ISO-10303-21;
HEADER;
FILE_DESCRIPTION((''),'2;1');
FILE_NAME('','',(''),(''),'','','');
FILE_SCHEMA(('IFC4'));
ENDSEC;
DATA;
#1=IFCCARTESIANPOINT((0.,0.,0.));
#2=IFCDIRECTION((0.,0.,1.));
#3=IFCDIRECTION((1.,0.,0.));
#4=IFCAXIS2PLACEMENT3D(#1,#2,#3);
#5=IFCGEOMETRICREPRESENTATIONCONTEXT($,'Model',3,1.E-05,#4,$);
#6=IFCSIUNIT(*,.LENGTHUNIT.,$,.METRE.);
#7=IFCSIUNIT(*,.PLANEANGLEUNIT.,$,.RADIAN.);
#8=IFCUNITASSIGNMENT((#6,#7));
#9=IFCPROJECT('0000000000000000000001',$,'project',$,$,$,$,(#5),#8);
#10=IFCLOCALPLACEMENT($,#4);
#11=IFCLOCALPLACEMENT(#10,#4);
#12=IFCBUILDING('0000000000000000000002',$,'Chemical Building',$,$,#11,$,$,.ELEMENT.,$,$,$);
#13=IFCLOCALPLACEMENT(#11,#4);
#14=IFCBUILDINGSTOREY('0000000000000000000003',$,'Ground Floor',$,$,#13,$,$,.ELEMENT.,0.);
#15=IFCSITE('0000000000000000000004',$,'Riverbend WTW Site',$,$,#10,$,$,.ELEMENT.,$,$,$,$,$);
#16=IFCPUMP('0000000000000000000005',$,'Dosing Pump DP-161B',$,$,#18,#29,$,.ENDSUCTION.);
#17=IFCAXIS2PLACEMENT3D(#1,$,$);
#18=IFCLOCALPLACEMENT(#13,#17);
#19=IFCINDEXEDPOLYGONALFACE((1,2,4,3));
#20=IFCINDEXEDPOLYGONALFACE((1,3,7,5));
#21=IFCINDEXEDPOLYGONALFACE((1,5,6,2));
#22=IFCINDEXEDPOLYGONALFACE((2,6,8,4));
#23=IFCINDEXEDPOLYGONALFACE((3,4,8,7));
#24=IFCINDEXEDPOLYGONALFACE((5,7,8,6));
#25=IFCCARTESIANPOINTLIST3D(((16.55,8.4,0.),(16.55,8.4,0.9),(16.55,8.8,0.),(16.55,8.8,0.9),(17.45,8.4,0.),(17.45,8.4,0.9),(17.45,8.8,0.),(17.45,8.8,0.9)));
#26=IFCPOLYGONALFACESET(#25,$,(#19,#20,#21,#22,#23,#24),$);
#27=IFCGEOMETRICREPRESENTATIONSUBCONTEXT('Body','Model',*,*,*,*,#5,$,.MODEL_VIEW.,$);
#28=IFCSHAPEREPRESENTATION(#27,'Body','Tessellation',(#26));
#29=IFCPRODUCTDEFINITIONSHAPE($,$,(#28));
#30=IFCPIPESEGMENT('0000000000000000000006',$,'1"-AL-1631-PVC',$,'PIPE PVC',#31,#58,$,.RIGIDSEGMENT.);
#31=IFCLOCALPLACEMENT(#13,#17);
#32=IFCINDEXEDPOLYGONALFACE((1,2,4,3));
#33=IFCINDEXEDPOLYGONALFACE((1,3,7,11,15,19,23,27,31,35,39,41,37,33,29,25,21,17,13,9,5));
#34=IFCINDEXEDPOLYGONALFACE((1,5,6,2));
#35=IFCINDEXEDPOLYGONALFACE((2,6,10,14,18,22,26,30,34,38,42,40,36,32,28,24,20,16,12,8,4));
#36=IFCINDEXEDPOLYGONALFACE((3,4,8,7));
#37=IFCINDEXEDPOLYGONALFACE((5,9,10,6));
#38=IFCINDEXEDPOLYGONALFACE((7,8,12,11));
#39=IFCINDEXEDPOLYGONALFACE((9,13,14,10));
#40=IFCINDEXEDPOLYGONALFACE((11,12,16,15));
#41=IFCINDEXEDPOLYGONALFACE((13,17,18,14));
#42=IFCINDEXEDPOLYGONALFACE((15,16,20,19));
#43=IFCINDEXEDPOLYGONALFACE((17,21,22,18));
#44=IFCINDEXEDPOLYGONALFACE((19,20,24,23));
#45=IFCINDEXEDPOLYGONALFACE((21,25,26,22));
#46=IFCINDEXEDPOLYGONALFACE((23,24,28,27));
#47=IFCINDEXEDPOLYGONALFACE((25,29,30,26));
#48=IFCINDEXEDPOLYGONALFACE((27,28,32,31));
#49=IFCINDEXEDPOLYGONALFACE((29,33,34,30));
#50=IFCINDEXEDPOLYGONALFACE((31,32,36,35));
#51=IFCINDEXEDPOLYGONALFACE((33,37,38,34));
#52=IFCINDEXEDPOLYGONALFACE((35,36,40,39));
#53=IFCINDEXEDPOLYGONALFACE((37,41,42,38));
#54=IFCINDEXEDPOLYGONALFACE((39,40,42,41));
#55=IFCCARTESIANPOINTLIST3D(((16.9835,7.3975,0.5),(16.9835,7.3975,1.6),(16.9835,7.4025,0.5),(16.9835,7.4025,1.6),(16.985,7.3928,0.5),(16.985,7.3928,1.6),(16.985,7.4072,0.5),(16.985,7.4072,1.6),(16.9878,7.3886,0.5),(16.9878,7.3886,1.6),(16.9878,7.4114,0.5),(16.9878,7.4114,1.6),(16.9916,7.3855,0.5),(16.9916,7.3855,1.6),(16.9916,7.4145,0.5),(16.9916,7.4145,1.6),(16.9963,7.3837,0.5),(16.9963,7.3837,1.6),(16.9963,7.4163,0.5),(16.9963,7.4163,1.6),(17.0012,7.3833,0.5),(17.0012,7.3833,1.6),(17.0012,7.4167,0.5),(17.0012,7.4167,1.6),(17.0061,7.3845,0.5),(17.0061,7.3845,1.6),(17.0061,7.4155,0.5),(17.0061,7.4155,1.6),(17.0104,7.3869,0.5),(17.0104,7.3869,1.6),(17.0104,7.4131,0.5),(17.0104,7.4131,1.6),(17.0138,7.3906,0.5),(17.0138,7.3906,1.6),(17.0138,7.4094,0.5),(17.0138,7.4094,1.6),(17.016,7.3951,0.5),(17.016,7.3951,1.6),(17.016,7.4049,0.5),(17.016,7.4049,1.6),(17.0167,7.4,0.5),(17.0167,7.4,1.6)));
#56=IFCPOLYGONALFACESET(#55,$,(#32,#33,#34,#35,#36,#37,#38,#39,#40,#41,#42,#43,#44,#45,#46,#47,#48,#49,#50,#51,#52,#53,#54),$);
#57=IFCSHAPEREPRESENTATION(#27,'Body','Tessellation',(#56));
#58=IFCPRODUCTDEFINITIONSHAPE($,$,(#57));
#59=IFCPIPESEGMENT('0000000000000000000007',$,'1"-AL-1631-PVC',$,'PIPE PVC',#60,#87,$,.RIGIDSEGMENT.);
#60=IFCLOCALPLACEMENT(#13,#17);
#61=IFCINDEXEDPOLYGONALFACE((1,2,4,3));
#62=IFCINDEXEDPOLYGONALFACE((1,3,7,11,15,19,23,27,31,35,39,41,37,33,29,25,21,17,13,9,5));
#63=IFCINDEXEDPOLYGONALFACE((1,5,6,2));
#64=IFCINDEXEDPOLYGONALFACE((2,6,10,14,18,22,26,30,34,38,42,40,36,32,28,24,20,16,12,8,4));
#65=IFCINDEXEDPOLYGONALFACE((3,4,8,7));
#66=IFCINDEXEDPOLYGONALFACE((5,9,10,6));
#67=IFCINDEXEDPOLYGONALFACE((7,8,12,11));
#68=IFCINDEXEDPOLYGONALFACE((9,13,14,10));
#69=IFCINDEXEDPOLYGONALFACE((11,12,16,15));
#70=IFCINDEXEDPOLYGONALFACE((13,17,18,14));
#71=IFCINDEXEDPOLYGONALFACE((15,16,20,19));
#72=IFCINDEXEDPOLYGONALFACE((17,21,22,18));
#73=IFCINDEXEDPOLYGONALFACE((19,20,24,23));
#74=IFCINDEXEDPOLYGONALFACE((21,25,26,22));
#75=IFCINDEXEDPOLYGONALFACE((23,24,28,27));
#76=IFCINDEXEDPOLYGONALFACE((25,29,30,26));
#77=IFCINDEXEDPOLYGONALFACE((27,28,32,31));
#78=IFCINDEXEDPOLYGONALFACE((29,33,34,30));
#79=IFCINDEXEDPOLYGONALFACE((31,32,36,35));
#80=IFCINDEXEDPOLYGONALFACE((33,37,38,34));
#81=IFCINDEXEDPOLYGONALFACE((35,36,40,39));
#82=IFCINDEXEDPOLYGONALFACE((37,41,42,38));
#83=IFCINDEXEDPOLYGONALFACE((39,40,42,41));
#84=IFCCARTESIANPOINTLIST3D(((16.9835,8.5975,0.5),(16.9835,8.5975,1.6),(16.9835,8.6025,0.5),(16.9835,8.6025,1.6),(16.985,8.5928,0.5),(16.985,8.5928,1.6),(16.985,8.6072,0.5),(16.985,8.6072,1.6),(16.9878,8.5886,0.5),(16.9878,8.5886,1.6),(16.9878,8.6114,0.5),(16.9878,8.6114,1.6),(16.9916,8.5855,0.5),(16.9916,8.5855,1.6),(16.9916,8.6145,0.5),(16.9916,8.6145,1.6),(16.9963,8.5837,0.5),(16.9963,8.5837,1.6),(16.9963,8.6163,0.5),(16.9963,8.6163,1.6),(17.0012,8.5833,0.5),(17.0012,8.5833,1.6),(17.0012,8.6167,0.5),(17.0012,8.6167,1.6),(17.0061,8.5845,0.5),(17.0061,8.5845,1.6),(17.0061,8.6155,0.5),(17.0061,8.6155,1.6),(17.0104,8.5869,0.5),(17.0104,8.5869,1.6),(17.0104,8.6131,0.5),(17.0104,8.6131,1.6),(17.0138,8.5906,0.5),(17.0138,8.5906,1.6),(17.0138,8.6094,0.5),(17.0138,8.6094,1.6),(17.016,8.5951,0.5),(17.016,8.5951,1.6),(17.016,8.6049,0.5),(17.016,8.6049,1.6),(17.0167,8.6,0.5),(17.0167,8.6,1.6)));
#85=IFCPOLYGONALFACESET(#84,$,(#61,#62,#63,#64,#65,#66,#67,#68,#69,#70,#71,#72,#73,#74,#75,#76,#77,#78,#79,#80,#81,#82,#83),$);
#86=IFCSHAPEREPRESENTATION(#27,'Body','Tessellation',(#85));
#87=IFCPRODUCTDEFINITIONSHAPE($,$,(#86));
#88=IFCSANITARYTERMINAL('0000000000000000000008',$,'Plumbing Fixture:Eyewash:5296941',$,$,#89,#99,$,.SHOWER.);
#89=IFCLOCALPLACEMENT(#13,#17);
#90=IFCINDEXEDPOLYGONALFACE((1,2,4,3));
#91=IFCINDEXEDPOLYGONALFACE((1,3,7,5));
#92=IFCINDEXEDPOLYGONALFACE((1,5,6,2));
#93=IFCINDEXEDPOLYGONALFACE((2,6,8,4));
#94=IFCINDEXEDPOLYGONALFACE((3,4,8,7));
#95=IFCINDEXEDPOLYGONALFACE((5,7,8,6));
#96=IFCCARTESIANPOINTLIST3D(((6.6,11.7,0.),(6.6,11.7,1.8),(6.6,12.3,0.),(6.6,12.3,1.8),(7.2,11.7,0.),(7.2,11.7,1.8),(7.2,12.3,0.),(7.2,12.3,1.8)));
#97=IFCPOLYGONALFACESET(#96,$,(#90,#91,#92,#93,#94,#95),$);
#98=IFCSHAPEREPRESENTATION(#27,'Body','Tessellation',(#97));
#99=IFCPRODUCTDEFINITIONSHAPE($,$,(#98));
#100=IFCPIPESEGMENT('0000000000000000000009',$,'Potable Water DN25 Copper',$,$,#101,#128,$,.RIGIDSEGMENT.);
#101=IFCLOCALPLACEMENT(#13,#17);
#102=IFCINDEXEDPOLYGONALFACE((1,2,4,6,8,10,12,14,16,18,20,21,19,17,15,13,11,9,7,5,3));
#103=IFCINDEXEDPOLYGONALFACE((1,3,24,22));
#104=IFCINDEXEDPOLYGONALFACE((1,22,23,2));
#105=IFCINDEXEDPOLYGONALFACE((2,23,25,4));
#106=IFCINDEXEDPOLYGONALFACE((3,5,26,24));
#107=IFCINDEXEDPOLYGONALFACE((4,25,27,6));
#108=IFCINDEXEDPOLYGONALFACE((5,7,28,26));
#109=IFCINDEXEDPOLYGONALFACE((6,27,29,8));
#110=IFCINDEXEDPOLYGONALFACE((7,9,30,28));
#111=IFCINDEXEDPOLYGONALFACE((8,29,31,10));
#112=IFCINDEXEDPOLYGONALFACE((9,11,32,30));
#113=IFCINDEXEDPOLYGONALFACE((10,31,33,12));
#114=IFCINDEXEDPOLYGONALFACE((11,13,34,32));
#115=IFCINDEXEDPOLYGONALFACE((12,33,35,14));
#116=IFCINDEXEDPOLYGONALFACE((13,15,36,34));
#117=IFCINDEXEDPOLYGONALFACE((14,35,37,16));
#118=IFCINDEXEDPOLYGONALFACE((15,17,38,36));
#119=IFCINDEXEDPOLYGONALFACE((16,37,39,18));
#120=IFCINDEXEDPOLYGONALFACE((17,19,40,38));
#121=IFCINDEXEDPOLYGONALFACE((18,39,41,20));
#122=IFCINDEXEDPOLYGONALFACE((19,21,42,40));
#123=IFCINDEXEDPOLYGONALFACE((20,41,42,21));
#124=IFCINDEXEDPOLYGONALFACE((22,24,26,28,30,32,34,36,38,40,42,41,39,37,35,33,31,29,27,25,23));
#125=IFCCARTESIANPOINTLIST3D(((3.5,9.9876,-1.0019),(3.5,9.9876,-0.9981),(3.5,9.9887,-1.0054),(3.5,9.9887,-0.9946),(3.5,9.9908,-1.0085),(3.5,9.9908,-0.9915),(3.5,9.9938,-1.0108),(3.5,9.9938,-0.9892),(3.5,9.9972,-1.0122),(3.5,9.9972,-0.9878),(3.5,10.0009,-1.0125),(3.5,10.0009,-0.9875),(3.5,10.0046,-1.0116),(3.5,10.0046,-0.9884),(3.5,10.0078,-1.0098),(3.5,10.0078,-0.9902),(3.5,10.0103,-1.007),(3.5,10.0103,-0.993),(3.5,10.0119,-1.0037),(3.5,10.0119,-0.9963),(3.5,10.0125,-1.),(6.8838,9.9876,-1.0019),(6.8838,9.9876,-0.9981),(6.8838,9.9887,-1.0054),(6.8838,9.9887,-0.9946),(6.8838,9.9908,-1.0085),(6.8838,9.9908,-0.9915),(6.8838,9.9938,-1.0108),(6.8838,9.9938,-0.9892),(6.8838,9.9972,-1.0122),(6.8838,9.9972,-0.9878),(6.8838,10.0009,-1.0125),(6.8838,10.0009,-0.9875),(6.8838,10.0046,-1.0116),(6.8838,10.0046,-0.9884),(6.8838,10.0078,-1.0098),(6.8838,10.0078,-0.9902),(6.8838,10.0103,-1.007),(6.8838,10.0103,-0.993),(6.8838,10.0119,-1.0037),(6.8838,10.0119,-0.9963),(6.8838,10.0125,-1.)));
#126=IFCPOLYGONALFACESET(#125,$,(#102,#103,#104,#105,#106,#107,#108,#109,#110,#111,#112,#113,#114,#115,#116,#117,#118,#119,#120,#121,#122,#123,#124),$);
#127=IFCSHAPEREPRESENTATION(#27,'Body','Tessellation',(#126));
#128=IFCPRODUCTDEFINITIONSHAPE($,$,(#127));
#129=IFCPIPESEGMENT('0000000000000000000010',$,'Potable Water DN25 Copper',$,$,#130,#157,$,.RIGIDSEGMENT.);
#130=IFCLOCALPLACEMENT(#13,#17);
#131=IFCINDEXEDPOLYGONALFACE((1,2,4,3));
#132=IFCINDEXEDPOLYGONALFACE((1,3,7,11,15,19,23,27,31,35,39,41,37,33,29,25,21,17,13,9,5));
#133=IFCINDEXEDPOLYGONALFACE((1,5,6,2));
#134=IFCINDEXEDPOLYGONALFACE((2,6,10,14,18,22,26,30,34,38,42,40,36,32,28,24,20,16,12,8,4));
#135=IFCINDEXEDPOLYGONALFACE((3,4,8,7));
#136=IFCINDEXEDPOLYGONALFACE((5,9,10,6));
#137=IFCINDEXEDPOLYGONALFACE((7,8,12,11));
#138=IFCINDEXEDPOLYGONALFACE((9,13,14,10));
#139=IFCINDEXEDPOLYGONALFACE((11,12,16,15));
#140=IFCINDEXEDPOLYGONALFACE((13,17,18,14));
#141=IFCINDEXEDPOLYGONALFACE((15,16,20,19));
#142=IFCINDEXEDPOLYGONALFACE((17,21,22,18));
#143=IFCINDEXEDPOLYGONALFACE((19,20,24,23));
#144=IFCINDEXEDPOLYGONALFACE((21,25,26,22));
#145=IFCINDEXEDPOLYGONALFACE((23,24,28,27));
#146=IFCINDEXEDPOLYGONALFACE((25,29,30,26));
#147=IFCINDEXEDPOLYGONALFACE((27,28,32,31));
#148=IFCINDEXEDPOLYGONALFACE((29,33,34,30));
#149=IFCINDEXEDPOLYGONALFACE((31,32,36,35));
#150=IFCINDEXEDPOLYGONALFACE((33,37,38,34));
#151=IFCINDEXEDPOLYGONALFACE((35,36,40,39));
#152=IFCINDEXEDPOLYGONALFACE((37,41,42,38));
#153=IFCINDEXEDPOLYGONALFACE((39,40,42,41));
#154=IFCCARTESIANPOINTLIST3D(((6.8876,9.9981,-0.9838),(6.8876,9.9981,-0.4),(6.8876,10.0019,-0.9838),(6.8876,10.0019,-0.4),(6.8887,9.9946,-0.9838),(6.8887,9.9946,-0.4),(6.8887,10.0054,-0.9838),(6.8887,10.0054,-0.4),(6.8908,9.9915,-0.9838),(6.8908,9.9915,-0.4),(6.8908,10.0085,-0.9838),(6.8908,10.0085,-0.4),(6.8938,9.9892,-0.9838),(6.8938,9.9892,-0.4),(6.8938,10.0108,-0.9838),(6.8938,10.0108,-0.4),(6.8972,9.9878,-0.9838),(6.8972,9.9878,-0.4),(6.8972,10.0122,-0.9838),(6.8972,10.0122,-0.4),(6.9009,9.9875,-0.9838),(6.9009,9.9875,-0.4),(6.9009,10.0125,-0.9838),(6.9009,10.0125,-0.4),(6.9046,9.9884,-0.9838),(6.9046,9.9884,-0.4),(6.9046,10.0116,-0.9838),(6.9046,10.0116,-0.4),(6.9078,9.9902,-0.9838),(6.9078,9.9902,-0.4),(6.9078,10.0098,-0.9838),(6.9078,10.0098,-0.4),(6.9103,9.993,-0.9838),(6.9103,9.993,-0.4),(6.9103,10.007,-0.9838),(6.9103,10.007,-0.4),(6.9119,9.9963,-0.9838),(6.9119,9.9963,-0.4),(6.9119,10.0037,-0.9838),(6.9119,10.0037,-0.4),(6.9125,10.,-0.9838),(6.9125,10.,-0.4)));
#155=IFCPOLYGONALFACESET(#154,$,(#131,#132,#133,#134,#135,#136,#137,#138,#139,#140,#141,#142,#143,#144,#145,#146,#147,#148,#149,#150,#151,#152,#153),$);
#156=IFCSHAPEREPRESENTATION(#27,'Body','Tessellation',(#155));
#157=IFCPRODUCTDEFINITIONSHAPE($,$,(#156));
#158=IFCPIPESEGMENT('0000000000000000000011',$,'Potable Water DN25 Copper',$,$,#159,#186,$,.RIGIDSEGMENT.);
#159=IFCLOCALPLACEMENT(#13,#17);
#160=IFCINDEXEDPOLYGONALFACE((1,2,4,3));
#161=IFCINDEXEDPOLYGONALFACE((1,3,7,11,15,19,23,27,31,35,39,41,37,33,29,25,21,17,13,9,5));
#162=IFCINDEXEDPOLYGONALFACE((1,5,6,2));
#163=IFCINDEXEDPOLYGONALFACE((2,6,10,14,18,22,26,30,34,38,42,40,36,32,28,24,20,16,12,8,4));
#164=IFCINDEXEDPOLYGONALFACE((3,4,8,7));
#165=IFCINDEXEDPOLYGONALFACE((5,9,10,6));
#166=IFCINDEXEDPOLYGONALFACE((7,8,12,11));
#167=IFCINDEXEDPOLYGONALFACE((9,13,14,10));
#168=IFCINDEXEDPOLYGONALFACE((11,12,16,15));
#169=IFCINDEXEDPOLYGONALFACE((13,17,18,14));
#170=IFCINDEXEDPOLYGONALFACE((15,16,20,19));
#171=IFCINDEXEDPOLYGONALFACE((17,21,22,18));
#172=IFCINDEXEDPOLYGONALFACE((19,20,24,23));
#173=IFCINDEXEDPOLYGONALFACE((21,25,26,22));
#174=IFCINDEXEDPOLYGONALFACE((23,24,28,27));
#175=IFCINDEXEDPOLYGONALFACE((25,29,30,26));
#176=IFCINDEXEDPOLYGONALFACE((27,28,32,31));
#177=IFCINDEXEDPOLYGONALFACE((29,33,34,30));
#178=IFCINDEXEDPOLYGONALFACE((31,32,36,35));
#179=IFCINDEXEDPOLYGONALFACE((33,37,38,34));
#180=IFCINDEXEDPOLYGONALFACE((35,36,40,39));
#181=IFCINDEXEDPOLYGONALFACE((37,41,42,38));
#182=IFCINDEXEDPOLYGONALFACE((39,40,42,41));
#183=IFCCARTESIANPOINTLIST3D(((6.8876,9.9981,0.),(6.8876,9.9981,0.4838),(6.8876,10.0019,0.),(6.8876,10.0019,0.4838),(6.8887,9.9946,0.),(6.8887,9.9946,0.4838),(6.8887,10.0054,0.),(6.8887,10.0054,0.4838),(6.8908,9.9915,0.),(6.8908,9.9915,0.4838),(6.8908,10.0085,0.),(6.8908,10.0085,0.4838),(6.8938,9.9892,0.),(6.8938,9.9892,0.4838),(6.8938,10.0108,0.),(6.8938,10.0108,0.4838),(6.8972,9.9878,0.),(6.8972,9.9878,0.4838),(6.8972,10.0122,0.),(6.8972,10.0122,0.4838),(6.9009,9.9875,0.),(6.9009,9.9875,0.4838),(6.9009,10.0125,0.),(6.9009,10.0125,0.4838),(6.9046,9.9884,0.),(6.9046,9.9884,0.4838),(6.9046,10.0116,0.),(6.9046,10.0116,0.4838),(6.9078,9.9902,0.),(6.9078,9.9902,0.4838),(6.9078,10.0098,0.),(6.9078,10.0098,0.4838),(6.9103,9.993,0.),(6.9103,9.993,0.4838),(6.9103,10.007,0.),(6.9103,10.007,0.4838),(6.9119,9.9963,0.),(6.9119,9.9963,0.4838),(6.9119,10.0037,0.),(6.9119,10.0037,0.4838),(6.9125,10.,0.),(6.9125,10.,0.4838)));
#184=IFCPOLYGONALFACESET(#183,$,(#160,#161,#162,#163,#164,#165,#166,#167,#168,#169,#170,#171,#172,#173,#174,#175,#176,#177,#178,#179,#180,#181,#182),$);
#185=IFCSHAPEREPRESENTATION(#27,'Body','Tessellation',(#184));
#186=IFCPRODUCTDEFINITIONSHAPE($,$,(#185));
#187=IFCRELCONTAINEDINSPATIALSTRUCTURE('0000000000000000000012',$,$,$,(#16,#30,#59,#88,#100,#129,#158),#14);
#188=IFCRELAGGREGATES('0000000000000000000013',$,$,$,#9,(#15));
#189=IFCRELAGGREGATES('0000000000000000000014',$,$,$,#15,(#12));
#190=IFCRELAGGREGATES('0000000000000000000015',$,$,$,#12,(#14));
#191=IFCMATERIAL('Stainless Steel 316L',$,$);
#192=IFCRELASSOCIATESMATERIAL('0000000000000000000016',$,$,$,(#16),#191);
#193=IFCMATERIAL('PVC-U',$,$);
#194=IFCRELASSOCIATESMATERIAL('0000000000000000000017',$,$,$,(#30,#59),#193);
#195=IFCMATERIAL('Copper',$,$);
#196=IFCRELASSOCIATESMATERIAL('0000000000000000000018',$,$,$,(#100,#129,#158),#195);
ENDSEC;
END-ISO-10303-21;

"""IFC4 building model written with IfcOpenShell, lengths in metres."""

from ifc_helpers import new_model, si_unit, frame, origin_with_axes, origin_2d, place, context, subcontext, project, spatial, rectangle, circle, extrude, material, element, save


model = new_model("IFC4")

# Units and contexts
model_context = context("Model", 3, precision=1e-05, world=origin_with_axes())
body_context = subcontext(model_context, "Body", "Model", "MODEL_VIEW")
ifc_project = project(units=[si_unit("LENGTHUNIT", "METRE"), si_unit("PLANEANGLEUNIT", "RADIAN")], contexts=[model_context])

# Site, building, storey
site_placement = place(None, origin_with_axes())
site = spatial("IfcSite", under=ifc_project, at=site_placement, Name="Riverbend WTW Site", CompositionType="ELEMENT")
building_placement = place(site_placement, origin_with_axes())
building = spatial("IfcBuilding", under=site, at=building_placement, Name="Chemical Building", CompositionType="ELEMENT")
storey_placement = place(building_placement, origin_with_axes())
storey = spatial("IfcBuildingStorey", under=building, at=storey_placement, Name="Ground Floor", CompositionType="ELEMENT", Elevation=0.0)

# Pump
ifc_material_1 = material(Name="Stainless Steel 316L")
for number, where, z_axis, x_axis, name in (
    (1, (17.0, 8.6, 0.45), (0.0, 0.0, 1.0), (1.0, 0.0, 0.0), "Dosing Pump DP-161B"),
):
    element("IfcPump", number, at=place(None, frame(where, z_axis=z_axis, x_axis=x_axis)), inside=storey, material=ifc_material_1, Name=name, PredefinedType="ENDSUCTION", context=body_context, shape_type="SweptSolid", body=[
        extrude(rectangle(XDim=0.9, YDim=0.4, at=origin_2d()), frame((0.0, 0.0, -0.45), z_axis=(0.0, 0.0, 1.0), x_axis=(1.0, 0.0, 0.0)), (0.0, 0.0, 1.0), 0.9),
    ])

# Pipe segments
ifc_material_2 = material(Name="PVC-U")
for number, where, z_axis, x_axis, name in (
    (2, (17.0, 7.4, 0.5), (0.0, 0.0, 1.0), (1.0, 0.0, 0.0), "1\"-AL-1631-PVC"),
    (3, (17.0, 8.6, 0.5), (0.0, 0.0, 1.0), (1.0, 0.0, 0.0), "1\"-AL-1631-PVC"),
):
    element("IfcPipeSegment", number, at=place(None, frame(where, z_axis=z_axis, x_axis=x_axis)), inside=storey, material=ifc_material_2, Name=name, ObjectType="PIPE PVC", PredefinedType="RIGIDSEGMENT", context=body_context, shape_type="SweptSolid", body=[
        extrude(circle(Radius=0.0167, at=origin_2d()), origin_with_axes(), (0.0, 0.0, 1.0), 1.1),
    ])

# Sanitary terminal
sanitary_terminal_1_placement = place(None, frame((6.9, 12.0, 0.9), z_axis=(0.0, 0.0, 1.0), x_axis=(1.0, 0.0, 0.0)))
element("IfcSanitaryTerminal", 4, at=sanitary_terminal_1_placement, inside=storey, Name="Plumbing Fixture:Eyewash:5296941", PredefinedType="SHOWER", context=body_context, shape_type="SweptSolid", body=[
    extrude(rectangle(XDim=0.6, YDim=0.6, at=origin_2d()), frame((0.0, 0.0, -0.9), z_axis=(0.0, 0.0, 1.0), x_axis=(1.0, 0.0, 0.0)), (0.0, 0.0, 1.0), 1.8),
])

# Pipe segments
ifc_material_3 = material(Name="Copper")
pipe_segment_1_placement = place(None, frame((3.5, 10.0, -1.0), z_axis=(0.0, 0.0, 1.0), x_axis=(1.0, 0.0, 0.0)))
element("IfcPipeSegment", 5, at=pipe_segment_1_placement, inside=storey, material=ifc_material_3, Name="Potable Water DN25 Copper", PredefinedType="RIGIDSEGMENT", context=body_context, shape_type="SweptSolid", body=[
    extrude(circle(Radius=0.0125, at=origin_2d()), frame((0.0, 0.0, 0.0), z_axis=(1.0, 0.0, 0.0), x_axis=(0.0, 1.0, 0.0)), (0.0, 0.0, 1.0), 3.3838),
])
pipe_segment_2_placement = place(None, frame((6.9, 10.0, -0.9838), z_axis=(0.0, 0.0, 1.0), x_axis=(1.0, 0.0, 0.0)))
element("IfcPipeSegment", 6, at=pipe_segment_2_placement, inside=storey, material=ifc_material_3, Name="Potable Water DN25 Copper", PredefinedType="RIGIDSEGMENT", context=body_context, shape_type="SweptSolid", body=[
    extrude(circle(Radius=0.0125, at=origin_2d()), origin_with_axes(), (0.0, 0.0, 1.0), 0.5837),
])
pipe_segment_3_placement = place(None, frame((6.9, 10.0, 0.0), z_axis=(0.0, 0.0, 1.0), x_axis=(1.0, 0.0, 0.0)))
element("IfcPipeSegment", 7, at=pipe_segment_3_placement, inside=storey, material=ifc_material_3, Name="Potable Water DN25 Copper", PredefinedType="RIGIDSEGMENT", context=body_context, shape_type="SweptSolid", body=[
    extrude(circle(Radius=0.0125, at=origin_2d()), origin_with_axes(), (0.0, 0.0, 1.0), 0.4838),
])

save(model, "model.ifc")
